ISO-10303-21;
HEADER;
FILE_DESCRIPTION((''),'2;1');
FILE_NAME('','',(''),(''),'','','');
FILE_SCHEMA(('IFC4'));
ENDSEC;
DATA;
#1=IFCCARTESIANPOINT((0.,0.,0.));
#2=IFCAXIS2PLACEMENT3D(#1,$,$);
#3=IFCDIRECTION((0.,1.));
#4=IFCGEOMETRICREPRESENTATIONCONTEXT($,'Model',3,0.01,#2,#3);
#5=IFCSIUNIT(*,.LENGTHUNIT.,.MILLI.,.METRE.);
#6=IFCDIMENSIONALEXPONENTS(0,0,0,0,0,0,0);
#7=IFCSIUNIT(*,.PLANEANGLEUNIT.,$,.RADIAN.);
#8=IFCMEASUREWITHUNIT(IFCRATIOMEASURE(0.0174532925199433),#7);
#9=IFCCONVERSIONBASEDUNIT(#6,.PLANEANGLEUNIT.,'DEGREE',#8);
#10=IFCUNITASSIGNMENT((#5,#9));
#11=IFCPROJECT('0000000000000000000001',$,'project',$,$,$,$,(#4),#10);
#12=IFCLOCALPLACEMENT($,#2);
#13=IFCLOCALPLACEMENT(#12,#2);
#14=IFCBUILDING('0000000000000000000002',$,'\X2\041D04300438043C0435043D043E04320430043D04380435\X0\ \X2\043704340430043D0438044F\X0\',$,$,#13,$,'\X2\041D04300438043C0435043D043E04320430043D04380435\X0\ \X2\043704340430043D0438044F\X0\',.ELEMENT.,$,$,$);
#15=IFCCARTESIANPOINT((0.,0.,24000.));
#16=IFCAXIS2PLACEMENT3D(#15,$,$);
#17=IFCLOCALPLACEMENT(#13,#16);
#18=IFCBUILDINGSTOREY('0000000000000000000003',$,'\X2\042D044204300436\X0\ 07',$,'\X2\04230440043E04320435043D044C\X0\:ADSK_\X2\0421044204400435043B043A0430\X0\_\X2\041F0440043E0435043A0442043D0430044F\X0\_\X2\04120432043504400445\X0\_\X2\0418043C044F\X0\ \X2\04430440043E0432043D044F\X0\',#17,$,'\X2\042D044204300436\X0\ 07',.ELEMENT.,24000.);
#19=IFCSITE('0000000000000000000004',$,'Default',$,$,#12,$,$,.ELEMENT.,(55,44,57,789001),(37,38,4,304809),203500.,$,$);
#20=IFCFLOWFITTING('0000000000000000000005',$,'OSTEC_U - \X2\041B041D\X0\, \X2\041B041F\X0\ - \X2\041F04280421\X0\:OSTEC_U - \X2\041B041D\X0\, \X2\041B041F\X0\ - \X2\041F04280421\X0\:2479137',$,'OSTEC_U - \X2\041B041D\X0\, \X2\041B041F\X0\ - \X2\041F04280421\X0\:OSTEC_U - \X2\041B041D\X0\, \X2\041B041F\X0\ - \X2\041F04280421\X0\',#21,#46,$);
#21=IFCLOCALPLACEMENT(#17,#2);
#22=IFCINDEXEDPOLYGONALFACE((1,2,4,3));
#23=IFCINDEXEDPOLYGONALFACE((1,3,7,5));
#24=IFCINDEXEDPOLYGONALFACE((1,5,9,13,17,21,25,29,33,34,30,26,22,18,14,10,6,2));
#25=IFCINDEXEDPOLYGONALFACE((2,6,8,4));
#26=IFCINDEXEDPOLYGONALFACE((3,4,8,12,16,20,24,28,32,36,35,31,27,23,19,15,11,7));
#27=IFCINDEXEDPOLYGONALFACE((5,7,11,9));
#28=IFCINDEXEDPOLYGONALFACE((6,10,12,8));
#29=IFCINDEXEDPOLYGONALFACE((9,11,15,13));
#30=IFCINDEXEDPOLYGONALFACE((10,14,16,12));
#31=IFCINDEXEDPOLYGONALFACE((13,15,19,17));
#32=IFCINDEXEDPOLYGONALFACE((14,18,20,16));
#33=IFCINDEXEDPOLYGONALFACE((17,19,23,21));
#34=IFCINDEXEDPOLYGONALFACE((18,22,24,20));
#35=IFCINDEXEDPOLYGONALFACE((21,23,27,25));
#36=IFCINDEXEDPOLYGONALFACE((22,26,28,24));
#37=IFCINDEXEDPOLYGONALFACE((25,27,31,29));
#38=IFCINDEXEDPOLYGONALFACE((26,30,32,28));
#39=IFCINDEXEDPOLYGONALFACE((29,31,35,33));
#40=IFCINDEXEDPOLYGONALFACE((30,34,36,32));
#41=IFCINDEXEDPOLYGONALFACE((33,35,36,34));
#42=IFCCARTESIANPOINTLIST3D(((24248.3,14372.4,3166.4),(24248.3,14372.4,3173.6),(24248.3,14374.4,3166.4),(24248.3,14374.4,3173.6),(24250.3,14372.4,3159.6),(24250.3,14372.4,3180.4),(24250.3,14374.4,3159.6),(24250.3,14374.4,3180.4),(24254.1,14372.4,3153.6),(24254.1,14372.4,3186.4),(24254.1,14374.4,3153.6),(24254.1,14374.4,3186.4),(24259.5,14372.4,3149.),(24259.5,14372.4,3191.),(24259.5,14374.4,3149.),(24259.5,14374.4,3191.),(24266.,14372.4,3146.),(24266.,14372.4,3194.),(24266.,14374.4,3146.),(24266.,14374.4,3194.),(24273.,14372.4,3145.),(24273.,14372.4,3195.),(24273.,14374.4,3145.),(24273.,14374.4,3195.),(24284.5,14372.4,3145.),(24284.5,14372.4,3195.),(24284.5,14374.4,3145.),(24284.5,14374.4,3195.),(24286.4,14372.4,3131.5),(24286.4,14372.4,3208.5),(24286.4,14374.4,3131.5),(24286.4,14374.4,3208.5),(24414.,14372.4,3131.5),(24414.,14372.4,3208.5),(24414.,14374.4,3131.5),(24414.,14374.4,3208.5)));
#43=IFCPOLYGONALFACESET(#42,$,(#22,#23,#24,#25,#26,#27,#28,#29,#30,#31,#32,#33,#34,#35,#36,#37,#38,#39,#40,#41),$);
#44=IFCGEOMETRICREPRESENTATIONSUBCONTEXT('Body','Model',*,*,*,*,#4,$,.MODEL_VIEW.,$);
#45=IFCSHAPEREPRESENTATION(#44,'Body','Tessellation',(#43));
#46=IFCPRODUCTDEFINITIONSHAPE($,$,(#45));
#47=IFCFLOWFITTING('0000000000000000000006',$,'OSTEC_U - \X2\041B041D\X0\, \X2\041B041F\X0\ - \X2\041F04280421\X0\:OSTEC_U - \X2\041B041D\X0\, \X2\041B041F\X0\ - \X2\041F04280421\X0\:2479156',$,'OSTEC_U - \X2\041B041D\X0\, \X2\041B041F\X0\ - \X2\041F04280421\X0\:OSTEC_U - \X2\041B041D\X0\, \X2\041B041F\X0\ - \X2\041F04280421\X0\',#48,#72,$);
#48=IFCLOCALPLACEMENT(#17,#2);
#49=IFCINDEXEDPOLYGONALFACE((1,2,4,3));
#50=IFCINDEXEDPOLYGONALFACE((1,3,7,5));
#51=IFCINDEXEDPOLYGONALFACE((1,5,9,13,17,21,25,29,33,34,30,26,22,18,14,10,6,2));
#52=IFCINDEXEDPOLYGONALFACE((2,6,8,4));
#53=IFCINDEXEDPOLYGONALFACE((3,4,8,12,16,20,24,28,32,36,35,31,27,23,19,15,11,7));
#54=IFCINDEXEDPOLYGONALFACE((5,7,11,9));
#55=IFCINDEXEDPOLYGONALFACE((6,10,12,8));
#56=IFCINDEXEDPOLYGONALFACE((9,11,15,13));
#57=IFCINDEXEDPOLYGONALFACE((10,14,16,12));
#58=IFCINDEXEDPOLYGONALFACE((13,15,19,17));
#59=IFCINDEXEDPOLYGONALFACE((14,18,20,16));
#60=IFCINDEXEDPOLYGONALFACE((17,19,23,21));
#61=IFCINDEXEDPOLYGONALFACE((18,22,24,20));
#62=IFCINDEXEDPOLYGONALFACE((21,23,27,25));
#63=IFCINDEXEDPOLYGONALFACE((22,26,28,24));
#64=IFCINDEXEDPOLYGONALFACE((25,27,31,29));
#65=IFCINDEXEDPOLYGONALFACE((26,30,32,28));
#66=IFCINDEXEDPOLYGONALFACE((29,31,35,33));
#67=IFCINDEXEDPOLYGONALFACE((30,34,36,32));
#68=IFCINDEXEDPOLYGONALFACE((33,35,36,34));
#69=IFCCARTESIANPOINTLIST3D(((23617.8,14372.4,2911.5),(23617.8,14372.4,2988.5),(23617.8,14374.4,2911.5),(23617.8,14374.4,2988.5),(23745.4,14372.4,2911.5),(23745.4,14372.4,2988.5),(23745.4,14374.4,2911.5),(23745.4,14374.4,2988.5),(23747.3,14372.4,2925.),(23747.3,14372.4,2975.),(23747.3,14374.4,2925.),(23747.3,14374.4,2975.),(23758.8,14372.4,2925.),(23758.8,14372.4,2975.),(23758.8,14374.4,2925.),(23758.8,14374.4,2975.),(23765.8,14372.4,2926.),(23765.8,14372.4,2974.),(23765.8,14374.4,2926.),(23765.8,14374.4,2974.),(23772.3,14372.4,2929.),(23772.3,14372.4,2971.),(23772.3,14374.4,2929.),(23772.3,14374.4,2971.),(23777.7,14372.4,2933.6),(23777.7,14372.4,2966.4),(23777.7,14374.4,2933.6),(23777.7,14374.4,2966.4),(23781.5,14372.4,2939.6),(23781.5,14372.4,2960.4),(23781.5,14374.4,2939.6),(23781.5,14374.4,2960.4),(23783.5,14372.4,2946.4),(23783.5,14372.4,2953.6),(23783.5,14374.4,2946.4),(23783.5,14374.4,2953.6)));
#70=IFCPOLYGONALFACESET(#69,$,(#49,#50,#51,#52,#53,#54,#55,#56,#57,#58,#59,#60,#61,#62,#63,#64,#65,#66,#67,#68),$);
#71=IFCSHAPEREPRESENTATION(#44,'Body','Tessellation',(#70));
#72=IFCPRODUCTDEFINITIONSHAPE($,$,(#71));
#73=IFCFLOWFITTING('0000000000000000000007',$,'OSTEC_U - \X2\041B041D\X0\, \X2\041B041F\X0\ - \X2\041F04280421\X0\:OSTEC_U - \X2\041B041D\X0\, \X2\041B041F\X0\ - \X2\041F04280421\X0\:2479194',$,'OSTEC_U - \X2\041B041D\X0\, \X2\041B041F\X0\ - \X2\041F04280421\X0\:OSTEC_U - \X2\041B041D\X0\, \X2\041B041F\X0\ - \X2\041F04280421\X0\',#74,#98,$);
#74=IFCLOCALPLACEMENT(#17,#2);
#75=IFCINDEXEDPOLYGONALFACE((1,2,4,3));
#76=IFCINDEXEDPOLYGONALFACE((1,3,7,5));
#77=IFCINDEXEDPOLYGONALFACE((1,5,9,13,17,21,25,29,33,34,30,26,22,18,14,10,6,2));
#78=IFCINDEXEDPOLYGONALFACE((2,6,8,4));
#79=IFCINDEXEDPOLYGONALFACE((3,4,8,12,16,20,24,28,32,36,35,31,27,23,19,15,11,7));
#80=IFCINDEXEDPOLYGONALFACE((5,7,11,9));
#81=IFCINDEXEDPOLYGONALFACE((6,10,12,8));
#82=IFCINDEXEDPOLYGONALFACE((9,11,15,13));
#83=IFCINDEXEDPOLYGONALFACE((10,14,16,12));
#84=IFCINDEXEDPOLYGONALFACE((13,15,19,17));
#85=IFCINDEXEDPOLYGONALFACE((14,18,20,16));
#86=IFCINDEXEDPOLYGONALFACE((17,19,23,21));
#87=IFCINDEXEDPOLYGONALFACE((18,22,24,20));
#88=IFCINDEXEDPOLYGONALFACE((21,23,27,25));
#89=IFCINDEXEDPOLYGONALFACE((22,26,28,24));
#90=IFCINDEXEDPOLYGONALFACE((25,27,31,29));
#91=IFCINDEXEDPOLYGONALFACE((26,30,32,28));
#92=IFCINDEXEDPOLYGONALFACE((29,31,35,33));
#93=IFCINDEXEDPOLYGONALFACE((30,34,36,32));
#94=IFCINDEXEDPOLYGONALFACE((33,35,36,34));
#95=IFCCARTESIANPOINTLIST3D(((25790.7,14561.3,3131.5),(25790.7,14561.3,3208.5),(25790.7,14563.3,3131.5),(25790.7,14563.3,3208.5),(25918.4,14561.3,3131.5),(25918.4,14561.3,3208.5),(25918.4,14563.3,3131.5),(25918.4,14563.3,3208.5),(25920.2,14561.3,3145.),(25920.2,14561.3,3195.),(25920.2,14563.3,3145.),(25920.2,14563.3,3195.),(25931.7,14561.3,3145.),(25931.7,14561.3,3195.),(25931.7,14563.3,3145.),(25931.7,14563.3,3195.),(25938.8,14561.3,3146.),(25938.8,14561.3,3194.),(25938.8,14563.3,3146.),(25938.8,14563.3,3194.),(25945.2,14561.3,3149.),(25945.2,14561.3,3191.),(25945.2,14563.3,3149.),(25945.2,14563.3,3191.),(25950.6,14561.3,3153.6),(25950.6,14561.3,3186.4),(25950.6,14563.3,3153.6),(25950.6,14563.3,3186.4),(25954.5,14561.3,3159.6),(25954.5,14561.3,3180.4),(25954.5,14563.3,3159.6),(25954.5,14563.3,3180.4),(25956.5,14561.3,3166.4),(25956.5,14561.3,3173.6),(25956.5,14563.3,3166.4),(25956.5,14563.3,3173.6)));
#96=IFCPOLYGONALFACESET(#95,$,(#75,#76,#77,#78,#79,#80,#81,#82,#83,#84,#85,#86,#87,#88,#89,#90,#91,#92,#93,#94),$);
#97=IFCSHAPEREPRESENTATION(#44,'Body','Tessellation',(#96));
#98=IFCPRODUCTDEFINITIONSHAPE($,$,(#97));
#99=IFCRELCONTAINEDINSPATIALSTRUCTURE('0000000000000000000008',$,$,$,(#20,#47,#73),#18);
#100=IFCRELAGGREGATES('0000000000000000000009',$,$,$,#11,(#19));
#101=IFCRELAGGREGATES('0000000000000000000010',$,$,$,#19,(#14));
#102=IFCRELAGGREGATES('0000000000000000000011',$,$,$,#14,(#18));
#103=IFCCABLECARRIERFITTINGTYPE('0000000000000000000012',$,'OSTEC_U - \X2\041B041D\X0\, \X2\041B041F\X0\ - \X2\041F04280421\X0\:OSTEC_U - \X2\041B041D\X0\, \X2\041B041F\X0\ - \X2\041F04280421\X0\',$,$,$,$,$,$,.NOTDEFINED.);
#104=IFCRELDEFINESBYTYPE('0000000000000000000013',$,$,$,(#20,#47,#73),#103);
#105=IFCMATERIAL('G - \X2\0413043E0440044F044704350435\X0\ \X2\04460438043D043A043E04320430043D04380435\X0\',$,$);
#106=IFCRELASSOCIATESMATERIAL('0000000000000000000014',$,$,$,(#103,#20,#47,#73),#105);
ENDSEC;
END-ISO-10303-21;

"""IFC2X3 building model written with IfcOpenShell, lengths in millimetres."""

from ifc_helpers import new_model, entity, si_unit, converted_unit, direction, frame, frame_2d, origin, place, context, subcontext, project, spatial, polyline, circle_curve, parameter, trimmed, segment, composite_curve, outline, extrude, source, transform, mapped, material, type_object, type_shapes, element, save


model = new_model("IFC2X3")

# Units and contexts
model_context = context("Model", 3, precision=0.01, world=origin(), true_north=direction((0.0, 1.0)))
body_context = subcontext(model_context, "Body", "Model", "MODEL_VIEW")
ifc_project = project(units=[si_unit("LENGTHUNIT", "METRE", prefix="MILLI"), converted_unit("PLANEANGLEUNIT", "DEGREE", entity("IfcRatioMeasure", 0.0174532925199433), si_unit("PLANEANGLEUNIT", "RADIAN"), dimensions=[0, 0, 0, 0, 0, 0, 0])], contexts=[model_context])

# Site, building, storey
site_placement = place(None, frame((0.0, 0.0, 0.0)))
site = spatial("IfcSite", under=ifc_project, at=site_placement, Name="Default", CompositionType="ELEMENT", RefLatitude=(55, 44, 57, 789001), RefLongitude=(37, 38, 4, 304809), RefElevation=203500.0)
building_placement = place(site_placement, origin())
building = spatial("IfcBuilding", under=site, at=building_placement, Name="Наименование здания", LongName="Наименование здания", CompositionType="ELEMENT")
storey_placement = place(building_placement, frame((0.0, 0.0, 24000.0)))
storey = spatial("IfcBuildingStorey", under=building, at=storey_placement, Name="Этаж 07", ObjectType="Уровень:ADSK_Стрелка_Проектная_Вверх_Имя уровня", LongName="Этаж 07", CompositionType="ELEMENT", Elevation=24000.0)

# Flow fittings
ifc_material_1 = material(Name="G - Горячее цинкование")
cable_carrier_fitting_type_1 = type_object("IfcCableCarrierFittingType", Name="OSTEC_U - ЛН, ЛП - ПШС:OSTEC_U - ЛН, ЛП - ПШС", PredefinedType="NOTDEFINED", material=ifc_material_1)
shared_shape_1 = source(origin(), body_context, "Body", "SweptSolid", [
    extrude(outline(composite_curve([segment(trimmed(circle_curve(frame_2d((-41.5, 0.0), x_axis=(1.0, 0.0)), 25.0), [parameter(90.0)], [parameter(270.0)], True, "PARAMETER"), True, "CONTINUOUS"), segment(polyline([(-41.5, -25.0), (-30.0, -25.0)]), True, "CONTINUOUS"), segment(polyline([(-30.0, -25.0), (-28.1, -38.5)]), True, "CONTINUOUS"), segment(polyline([(-28.1, -38.5), (99.5, -38.5)]), True, "CONTINUOUS"), segment(polyline([(99.5, -38.5), (99.5, 38.5)]), True, "CONTINUOUS"), segment(polyline([(99.5, 38.5), (-28.1, 38.5)]), True, "CONTINUOUS"), segment(polyline([(-28.1, 38.5), (-30.0, 25.0)]), True, "CONTINUOUS"), segment(polyline([(-30.0, 25.0), (-41.5, 25.0)]), True, "CONTINUOUS")], self_intersect=False)), frame((41.5, 0.0, 0.0)), (0.0, 0.0, 1.0), 2.0),
])
type_shapes(cable_carrier_fitting_type_1, [shared_shape_1])
for number, where, z_axis, x_axis, name in (
    (1, (24273.0, 14374.4, 3170.0), (0.0, -1.0, 0.0), (1.0, 0.0, 0.0), "OSTEC_U - ЛН, ЛП - ПШС:OSTEC_U - ЛН, ЛП - ПШС:2479137"),
    (2, (23758.8, 14374.4, 2950.0), (0.0, -1.0, 0.0), (-1.0, 0.0, 0.0), "OSTEC_U - ЛН, ЛП - ПШС:OSTEC_U - ЛН, ЛП - ПШС:2479156"),
    (3, (25931.7, 14561.3, 3170.0), (0.0, 1.0, 0.0), (-1.0, 0.0, 0.0), "OSTEC_U - ЛН, ЛП - ПШС:OSTEC_U - ЛН, ЛП - ПШС:2479194"),
):
    element("IfcFlowFitting", number, at=place(storey_placement, frame(where, z_axis=z_axis, x_axis=x_axis)), inside=storey, type_object=cable_carrier_fitting_type_1, material=ifc_material_1, Name=name, ObjectType="OSTEC_U - ЛН, ЛП - ПШС:OSTEC_U - ЛН, ЛП - ПШС", context=body_context, shape_type="MappedRepresentation", body=[
        mapped(shared_shape_1, transform((0.0, 0.0, 0.0), scale=1.0)),
    ])

save(model, "model.ifc")
